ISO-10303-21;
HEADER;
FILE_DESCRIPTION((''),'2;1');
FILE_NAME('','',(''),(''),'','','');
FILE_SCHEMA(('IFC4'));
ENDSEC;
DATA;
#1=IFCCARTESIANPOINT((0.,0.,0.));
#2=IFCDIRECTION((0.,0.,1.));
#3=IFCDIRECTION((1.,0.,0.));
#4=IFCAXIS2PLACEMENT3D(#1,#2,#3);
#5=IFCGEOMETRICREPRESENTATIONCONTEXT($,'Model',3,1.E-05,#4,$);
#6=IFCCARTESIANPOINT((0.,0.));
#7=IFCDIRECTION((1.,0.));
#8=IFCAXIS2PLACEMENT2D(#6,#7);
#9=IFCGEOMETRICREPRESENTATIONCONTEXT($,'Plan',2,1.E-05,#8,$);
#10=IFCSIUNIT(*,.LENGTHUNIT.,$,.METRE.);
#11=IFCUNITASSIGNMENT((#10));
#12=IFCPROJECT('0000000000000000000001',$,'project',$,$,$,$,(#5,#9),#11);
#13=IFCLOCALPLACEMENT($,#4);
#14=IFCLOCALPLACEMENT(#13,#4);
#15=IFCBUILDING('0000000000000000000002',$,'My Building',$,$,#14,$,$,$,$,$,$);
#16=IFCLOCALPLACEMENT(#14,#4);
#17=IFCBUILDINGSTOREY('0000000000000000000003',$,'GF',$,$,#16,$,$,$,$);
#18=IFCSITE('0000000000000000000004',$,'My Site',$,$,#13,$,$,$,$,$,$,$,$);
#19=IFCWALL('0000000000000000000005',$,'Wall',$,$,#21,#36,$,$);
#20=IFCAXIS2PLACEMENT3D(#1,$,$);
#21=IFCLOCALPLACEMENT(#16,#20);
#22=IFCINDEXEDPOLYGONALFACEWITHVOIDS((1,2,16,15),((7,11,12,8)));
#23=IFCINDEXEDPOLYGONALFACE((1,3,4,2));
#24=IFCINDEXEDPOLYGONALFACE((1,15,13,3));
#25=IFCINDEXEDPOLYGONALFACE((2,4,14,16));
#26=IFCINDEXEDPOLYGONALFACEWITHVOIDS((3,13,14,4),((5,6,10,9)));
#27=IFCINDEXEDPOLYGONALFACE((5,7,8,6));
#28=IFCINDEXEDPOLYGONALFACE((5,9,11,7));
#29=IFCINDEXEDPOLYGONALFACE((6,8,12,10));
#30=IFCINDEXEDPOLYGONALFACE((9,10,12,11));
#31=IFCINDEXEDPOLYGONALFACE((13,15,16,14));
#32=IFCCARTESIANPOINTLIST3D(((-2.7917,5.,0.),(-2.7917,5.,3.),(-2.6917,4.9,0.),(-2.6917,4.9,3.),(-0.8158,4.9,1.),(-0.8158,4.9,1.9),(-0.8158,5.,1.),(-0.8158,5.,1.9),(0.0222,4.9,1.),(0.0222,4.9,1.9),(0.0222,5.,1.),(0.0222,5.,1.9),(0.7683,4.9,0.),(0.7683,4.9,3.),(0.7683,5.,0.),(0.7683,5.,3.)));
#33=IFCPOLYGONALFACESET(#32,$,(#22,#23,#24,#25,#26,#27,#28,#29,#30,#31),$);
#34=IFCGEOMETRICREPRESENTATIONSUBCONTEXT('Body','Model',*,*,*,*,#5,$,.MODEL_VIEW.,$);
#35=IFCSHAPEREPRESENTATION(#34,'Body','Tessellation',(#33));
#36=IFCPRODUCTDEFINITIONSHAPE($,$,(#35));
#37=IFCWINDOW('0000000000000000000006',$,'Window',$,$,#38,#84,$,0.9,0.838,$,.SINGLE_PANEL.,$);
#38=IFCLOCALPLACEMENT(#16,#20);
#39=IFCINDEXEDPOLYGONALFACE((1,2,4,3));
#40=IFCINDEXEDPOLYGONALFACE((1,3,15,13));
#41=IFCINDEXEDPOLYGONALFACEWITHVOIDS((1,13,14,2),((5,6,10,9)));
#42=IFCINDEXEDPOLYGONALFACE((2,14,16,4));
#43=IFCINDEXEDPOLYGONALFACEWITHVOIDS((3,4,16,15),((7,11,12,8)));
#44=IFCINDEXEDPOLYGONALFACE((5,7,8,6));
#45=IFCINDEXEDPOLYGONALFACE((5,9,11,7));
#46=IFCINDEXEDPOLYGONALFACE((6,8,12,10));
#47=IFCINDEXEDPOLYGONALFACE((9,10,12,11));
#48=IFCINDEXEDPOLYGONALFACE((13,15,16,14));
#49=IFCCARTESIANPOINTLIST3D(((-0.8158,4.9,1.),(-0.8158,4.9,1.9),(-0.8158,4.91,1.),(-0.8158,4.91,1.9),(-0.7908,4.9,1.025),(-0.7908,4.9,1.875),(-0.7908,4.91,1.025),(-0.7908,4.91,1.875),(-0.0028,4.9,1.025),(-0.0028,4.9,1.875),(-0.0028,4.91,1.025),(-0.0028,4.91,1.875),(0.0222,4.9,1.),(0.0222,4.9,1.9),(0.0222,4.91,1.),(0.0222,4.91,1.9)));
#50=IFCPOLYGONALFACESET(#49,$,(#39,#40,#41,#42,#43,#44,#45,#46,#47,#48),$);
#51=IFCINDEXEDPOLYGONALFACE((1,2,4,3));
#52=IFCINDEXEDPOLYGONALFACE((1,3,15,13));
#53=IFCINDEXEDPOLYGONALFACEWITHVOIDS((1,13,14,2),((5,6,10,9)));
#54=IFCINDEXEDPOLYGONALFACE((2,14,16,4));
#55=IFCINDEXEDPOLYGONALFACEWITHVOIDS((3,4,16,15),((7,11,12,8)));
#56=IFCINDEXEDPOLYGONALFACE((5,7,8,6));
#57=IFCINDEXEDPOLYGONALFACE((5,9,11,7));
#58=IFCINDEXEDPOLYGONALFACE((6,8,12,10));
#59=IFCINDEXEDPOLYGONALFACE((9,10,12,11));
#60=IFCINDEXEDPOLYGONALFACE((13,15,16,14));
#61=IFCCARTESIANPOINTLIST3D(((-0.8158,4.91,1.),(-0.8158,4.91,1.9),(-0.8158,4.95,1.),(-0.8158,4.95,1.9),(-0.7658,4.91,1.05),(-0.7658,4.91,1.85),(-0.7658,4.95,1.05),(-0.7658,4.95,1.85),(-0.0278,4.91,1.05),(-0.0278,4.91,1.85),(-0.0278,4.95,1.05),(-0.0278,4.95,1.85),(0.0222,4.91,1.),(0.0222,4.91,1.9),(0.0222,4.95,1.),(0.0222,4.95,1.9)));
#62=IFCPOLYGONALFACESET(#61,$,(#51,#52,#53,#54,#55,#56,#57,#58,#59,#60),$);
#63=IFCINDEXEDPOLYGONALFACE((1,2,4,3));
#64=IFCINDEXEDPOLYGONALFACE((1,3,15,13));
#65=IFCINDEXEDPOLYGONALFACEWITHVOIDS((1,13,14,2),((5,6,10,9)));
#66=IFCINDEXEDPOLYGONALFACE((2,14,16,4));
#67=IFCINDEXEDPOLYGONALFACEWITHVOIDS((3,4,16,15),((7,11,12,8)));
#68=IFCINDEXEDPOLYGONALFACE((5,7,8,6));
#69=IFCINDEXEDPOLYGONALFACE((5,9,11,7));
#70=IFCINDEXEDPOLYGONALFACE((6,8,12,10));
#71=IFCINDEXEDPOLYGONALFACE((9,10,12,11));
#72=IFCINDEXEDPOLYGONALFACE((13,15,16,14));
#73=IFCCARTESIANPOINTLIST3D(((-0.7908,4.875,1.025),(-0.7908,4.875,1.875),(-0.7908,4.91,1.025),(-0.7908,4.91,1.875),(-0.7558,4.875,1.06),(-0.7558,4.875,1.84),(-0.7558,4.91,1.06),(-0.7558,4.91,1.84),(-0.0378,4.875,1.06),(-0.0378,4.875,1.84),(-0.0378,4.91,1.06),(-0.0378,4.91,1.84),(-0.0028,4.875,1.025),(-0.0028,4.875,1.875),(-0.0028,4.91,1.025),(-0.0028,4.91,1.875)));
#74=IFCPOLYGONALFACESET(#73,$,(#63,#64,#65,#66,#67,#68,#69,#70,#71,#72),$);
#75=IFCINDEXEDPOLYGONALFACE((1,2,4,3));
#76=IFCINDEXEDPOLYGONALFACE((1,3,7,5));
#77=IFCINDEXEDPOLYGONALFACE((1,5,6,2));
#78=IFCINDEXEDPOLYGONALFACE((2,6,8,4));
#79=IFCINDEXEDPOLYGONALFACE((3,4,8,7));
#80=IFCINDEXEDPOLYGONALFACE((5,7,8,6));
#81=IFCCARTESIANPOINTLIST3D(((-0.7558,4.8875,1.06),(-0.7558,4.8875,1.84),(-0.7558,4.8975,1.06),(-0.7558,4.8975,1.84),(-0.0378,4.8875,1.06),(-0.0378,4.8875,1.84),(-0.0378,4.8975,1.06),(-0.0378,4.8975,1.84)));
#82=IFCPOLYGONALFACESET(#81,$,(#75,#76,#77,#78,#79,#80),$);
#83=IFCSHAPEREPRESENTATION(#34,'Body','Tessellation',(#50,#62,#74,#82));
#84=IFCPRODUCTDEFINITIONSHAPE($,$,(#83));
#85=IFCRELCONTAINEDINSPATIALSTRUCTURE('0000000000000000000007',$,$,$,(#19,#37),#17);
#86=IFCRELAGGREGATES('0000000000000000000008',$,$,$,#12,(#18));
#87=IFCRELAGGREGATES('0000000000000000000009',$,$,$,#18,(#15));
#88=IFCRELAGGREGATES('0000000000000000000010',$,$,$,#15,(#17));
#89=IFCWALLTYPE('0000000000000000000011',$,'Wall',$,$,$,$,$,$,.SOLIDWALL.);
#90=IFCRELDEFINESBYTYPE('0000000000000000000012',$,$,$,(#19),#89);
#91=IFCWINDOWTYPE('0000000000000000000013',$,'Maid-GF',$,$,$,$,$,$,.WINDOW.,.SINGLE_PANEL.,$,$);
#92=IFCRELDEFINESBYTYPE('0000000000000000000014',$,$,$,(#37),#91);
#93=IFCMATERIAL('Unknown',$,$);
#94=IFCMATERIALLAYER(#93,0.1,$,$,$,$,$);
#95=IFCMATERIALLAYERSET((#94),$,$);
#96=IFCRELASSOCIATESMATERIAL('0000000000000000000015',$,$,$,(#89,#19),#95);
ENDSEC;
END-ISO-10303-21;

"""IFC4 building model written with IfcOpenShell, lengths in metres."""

from ifc_helpers import new_model, entity, si_unit, frame, origin_with_axes, origin_2d_with_axis, place, context, subcontext, project, spatial, line, indexed_curve, outline, extrude, shape, source, transform, mapped, material, layer, layer_set, layer_usage, type_object, type_shapes, element, fill, save


model = new_model("IFC4")

# Units and contexts
model_context = context("Model", 3, precision=1e-05, world=origin_with_axes())
plan_context = context("Plan", 2, precision=1e-05, world=origin_2d_with_axis())
body_context_1 = subcontext(model_context, "Body", "Model", "MODEL_VIEW")
body_context_2 = subcontext(plan_context, "Body", "Plan", "PLAN_VIEW")
ifc_project = project(units=[si_unit("LENGTHUNIT", "METRE")], contexts=[model_context, plan_context])

# Site, building, storey
site_placement = place(None, origin_with_axes())
site = spatial("IfcSite", under=ifc_project, at=site_placement, Name="My Site")
building_placement = place(site_placement, origin_with_axes())
building = spatial("IfcBuilding", under=site, at=building_placement, Name="My Building")
storey_placement = place(building_placement, origin_with_axes())
storey = spatial("IfcBuildingStorey", under=building, at=storey_placement, Name="GF")

# Shared definitions
ifc_material_1 = material(Name="Unknown")
ifc_layer = layer(ifc_material_1, 0.1)
ifc_layer_set = layer_set([ifc_layer])
wall_type = type_object("IfcWallType", Name="Wall", PredefinedType="SOLIDWALL", material=ifc_layer_set)

# Wall, opening, window
ifc_layer_usage_1 = layer_usage(ifc_layer_set, "AXIS2", "POSITIVE", 0.0)
wall_1_placement = place(storey_placement, frame((0.7683, 5.0, 0.0), z_axis=(0.0, 0.0, 1.0), x_axis=(-1.0, 0.0, 0.0)))
wall_1 = element("IfcWall", 1, at=wall_1_placement, inside=storey, type_object=wall_type, material=ifc_layer_usage_1, Name="Wall", context=body_context_1, shape_type="SweptSolid", body=[
    extrude(outline(indexed_curve([(0.0, 0.0), (0.0, 0.1), (3.46, 0.1), (3.56, 0.0)], segments=[line(1, 2, 3, 4, 1)])), origin_with_axes(), (0.0, 0.0, 1.0), 3.0),
])
shared_shape_1 = source(origin_with_axes(), body_context_1, "Body", "SweptSolid", [
    extrude(outline(indexed_curve([(0.0, 0.0), (0.838, 0.0), (0.838, 0.9), (0.0, 0.9)], segments=[line(1, 2, 3, 4, 1)])), frame((0.0, -0.6, 0.0), z_axis=(0.0, -1.0, 0.0), x_axis=(1.0, 0.0, 0.0)), (0.0, 0.0, -1.0), 1.2),
])
opening_1_placement = place(wall_1_placement, frame((0.7462, 0.0, 1.0), z_axis=(0.0, 0.0, 1.0), x_axis=(1.0, 0.0, 0.0)))
opening_1 = element("IfcOpeningElement", 2, at=opening_1_placement, cuts=wall_1, PredefinedType="OPENING", context=body_context_1, shape_type="MappedRepresentation", body=[
    mapped(shared_shape_1, transform((0.0, 0.0, 0.0), x_axis=(1.0, 0.0, 0.0), y_axis=(0.0, 1.0, 0.0), z_axis=(0.0, 0.0, 1.0), scale=1.0)),
])
window_type_1 = type_object("IfcWindowType", Name="Maid-GF", PartitioningType="SINGLE_PANEL", PredefinedType="WINDOW")
shared_shape_2 = source(origin_with_axes(), body_context_1, "Body", "SweptSolid", [
    extrude(outline(indexed_curve([(0.0, 0.0), (0.838, 0.0), (0.838, 0.9), (0.0, 0.9)], segments=[line(1, 2, 3, 4, 1)]), holes=[indexed_curve([(0.025, 0.025), (0.813, 0.025), (0.813, 0.875), (0.025, 0.875)], segments=[line(1, 2, 3, 4, 1)])]), frame((0.0, 0.09, 0.0), z_axis=(0.0, -1.0, 0.0), x_axis=(1.0, 0.0, 0.0)), (0.0, 0.0, -1.0), 0.01),
    extrude(outline(indexed_curve([(0.0, 0.0), (0.838, 0.0), (0.838, 0.9), (0.0, 0.9)], segments=[line(1, 2, 3, 4, 1)]), holes=[indexed_curve([(0.05, 0.05), (0.788, 0.05), (0.788, 0.85), (0.05, 0.85)], segments=[line(1, 2, 3, 4, 1)])]), frame((0.0, 0.05, 0.0), z_axis=(0.0, -1.0, 0.0), x_axis=(1.0, 0.0, 0.0)), (0.0, 0.0, -1.0), 0.04),
    extrude(outline(indexed_curve([(0.0, 0.0), (0.788, 0.0), (0.788, 0.85), (0.0, 0.85)], segments=[line(1, 2, 3, 4, 1)]), holes=[indexed_curve([(0.035, 0.035), (0.753, 0.035), (0.753, 0.815), (0.035, 0.815)], segments=[line(1, 2, 3, 4, 1)])]), frame((0.025, 0.09, 0.025), z_axis=(0.0, -1.0, 0.0), x_axis=(1.0, 0.0, 0.0)), (0.0, 0.0, -1.0), 0.035),
    extrude(outline(indexed_curve([(0.035, 0.035), (0.753, 0.035), (0.753, 0.815), (0.035, 0.815)], segments=[line(1, 2, 3, 4, 1)])), frame((0.025, 0.1025, 0.025), z_axis=(0.0, -1.0, 0.0), x_axis=(1.0, 0.0, 0.0)), (0.0, 0.0, -1.0), 0.01),
])
shared_shape_3 = source(origin_with_axes(), body_context_2, "Body", "Curve2D", [
    entity("IfcIndexedPolyCurve", entity("IfcCartesianPointList2D", [[0.05, 0.05], [0.788, 0.05]])),
    entity("IfcIndexedPolyCurve", entity("IfcCartesianPointList2D", [[0.0, 0.1], [0.025, 0.1], [0.025, 0.09], [0.05, 0.09], [0.05, 0.05], [0.0, 0.05]]), [entity("IfcLineIndex", [1, 2, 3, 4, 5, 6, 1])]),
    entity("IfcIndexedPolyCurve", entity("IfcCartesianPointList2D", [[0.838, 0.1], [0.813, 0.1], [0.813, 0.09], [0.788, 0.09], [0.788, 0.05], [0.838, 0.05]]), [entity("IfcLineIndex", [1, 2, 3, 4, 5, 6, 1])]),
    entity("IfcIndexedPolyCurve", entity("IfcCartesianPointList2D", [[0.025, 0.09], [0.06, 0.09], [0.06, 0.125], [0.025, 0.125]]), [entity("IfcLineIndex", [1, 2, 3, 4, 1])]),
    entity("IfcIndexedPolyCurve", entity("IfcCartesianPointList2D", [[0.813, 0.09], [0.778, 0.09], [0.778, 0.125], [0.813, 0.125]]), [entity("IfcLineIndex", [1, 2, 3, 4, 1])]),
    entity("IfcIndexedPolyCurve", entity("IfcCartesianPointList2D", [[0.06, 0.09], [0.778, 0.09]])),
    entity("IfcIndexedPolyCurve", entity("IfcCartesianPointList2D", [[0.06, 0.125], [0.778, 0.125]])),
    entity("IfcIndexedPolyCurve", entity("IfcCartesianPointList2D", [[0.06, 0.1075], [0.778, 0.1075]])),
])
type_shapes(window_type_1, [shared_shape_2, shared_shape_3])
window_1_placement = place(opening_1_placement, origin_with_axes())
window_1 = element("IfcWindow", 3, at=window_1_placement, inside=storey, type_object=window_type_1, Name="Window", OverallHeight=0.9, OverallWidth=0.838, PartitioningType="SINGLE_PANEL", shapes=[
    shape(body_context_1, "Body", "MappedRepresentation", [mapped(shared_shape_2, transform((0.0, 0.0, 0.0), x_axis=(1.0, 0.0, 0.0), y_axis=(0.0, 1.0, 0.0), z_axis=(0.0, 0.0, 1.0), scale=1.0))]),
    shape(body_context_2, "Body", "MappedRepresentation", [mapped(shared_shape_3, transform((0.0, 0.0, 0.0), x_axis=(1.0, 0.0, 0.0), y_axis=(0.0, 1.0, 0.0), z_axis=(0.0, 0.0, 1.0), scale=1.0))]),
])
fill(opening_1, window_1)

save(model, "model.ifc")
